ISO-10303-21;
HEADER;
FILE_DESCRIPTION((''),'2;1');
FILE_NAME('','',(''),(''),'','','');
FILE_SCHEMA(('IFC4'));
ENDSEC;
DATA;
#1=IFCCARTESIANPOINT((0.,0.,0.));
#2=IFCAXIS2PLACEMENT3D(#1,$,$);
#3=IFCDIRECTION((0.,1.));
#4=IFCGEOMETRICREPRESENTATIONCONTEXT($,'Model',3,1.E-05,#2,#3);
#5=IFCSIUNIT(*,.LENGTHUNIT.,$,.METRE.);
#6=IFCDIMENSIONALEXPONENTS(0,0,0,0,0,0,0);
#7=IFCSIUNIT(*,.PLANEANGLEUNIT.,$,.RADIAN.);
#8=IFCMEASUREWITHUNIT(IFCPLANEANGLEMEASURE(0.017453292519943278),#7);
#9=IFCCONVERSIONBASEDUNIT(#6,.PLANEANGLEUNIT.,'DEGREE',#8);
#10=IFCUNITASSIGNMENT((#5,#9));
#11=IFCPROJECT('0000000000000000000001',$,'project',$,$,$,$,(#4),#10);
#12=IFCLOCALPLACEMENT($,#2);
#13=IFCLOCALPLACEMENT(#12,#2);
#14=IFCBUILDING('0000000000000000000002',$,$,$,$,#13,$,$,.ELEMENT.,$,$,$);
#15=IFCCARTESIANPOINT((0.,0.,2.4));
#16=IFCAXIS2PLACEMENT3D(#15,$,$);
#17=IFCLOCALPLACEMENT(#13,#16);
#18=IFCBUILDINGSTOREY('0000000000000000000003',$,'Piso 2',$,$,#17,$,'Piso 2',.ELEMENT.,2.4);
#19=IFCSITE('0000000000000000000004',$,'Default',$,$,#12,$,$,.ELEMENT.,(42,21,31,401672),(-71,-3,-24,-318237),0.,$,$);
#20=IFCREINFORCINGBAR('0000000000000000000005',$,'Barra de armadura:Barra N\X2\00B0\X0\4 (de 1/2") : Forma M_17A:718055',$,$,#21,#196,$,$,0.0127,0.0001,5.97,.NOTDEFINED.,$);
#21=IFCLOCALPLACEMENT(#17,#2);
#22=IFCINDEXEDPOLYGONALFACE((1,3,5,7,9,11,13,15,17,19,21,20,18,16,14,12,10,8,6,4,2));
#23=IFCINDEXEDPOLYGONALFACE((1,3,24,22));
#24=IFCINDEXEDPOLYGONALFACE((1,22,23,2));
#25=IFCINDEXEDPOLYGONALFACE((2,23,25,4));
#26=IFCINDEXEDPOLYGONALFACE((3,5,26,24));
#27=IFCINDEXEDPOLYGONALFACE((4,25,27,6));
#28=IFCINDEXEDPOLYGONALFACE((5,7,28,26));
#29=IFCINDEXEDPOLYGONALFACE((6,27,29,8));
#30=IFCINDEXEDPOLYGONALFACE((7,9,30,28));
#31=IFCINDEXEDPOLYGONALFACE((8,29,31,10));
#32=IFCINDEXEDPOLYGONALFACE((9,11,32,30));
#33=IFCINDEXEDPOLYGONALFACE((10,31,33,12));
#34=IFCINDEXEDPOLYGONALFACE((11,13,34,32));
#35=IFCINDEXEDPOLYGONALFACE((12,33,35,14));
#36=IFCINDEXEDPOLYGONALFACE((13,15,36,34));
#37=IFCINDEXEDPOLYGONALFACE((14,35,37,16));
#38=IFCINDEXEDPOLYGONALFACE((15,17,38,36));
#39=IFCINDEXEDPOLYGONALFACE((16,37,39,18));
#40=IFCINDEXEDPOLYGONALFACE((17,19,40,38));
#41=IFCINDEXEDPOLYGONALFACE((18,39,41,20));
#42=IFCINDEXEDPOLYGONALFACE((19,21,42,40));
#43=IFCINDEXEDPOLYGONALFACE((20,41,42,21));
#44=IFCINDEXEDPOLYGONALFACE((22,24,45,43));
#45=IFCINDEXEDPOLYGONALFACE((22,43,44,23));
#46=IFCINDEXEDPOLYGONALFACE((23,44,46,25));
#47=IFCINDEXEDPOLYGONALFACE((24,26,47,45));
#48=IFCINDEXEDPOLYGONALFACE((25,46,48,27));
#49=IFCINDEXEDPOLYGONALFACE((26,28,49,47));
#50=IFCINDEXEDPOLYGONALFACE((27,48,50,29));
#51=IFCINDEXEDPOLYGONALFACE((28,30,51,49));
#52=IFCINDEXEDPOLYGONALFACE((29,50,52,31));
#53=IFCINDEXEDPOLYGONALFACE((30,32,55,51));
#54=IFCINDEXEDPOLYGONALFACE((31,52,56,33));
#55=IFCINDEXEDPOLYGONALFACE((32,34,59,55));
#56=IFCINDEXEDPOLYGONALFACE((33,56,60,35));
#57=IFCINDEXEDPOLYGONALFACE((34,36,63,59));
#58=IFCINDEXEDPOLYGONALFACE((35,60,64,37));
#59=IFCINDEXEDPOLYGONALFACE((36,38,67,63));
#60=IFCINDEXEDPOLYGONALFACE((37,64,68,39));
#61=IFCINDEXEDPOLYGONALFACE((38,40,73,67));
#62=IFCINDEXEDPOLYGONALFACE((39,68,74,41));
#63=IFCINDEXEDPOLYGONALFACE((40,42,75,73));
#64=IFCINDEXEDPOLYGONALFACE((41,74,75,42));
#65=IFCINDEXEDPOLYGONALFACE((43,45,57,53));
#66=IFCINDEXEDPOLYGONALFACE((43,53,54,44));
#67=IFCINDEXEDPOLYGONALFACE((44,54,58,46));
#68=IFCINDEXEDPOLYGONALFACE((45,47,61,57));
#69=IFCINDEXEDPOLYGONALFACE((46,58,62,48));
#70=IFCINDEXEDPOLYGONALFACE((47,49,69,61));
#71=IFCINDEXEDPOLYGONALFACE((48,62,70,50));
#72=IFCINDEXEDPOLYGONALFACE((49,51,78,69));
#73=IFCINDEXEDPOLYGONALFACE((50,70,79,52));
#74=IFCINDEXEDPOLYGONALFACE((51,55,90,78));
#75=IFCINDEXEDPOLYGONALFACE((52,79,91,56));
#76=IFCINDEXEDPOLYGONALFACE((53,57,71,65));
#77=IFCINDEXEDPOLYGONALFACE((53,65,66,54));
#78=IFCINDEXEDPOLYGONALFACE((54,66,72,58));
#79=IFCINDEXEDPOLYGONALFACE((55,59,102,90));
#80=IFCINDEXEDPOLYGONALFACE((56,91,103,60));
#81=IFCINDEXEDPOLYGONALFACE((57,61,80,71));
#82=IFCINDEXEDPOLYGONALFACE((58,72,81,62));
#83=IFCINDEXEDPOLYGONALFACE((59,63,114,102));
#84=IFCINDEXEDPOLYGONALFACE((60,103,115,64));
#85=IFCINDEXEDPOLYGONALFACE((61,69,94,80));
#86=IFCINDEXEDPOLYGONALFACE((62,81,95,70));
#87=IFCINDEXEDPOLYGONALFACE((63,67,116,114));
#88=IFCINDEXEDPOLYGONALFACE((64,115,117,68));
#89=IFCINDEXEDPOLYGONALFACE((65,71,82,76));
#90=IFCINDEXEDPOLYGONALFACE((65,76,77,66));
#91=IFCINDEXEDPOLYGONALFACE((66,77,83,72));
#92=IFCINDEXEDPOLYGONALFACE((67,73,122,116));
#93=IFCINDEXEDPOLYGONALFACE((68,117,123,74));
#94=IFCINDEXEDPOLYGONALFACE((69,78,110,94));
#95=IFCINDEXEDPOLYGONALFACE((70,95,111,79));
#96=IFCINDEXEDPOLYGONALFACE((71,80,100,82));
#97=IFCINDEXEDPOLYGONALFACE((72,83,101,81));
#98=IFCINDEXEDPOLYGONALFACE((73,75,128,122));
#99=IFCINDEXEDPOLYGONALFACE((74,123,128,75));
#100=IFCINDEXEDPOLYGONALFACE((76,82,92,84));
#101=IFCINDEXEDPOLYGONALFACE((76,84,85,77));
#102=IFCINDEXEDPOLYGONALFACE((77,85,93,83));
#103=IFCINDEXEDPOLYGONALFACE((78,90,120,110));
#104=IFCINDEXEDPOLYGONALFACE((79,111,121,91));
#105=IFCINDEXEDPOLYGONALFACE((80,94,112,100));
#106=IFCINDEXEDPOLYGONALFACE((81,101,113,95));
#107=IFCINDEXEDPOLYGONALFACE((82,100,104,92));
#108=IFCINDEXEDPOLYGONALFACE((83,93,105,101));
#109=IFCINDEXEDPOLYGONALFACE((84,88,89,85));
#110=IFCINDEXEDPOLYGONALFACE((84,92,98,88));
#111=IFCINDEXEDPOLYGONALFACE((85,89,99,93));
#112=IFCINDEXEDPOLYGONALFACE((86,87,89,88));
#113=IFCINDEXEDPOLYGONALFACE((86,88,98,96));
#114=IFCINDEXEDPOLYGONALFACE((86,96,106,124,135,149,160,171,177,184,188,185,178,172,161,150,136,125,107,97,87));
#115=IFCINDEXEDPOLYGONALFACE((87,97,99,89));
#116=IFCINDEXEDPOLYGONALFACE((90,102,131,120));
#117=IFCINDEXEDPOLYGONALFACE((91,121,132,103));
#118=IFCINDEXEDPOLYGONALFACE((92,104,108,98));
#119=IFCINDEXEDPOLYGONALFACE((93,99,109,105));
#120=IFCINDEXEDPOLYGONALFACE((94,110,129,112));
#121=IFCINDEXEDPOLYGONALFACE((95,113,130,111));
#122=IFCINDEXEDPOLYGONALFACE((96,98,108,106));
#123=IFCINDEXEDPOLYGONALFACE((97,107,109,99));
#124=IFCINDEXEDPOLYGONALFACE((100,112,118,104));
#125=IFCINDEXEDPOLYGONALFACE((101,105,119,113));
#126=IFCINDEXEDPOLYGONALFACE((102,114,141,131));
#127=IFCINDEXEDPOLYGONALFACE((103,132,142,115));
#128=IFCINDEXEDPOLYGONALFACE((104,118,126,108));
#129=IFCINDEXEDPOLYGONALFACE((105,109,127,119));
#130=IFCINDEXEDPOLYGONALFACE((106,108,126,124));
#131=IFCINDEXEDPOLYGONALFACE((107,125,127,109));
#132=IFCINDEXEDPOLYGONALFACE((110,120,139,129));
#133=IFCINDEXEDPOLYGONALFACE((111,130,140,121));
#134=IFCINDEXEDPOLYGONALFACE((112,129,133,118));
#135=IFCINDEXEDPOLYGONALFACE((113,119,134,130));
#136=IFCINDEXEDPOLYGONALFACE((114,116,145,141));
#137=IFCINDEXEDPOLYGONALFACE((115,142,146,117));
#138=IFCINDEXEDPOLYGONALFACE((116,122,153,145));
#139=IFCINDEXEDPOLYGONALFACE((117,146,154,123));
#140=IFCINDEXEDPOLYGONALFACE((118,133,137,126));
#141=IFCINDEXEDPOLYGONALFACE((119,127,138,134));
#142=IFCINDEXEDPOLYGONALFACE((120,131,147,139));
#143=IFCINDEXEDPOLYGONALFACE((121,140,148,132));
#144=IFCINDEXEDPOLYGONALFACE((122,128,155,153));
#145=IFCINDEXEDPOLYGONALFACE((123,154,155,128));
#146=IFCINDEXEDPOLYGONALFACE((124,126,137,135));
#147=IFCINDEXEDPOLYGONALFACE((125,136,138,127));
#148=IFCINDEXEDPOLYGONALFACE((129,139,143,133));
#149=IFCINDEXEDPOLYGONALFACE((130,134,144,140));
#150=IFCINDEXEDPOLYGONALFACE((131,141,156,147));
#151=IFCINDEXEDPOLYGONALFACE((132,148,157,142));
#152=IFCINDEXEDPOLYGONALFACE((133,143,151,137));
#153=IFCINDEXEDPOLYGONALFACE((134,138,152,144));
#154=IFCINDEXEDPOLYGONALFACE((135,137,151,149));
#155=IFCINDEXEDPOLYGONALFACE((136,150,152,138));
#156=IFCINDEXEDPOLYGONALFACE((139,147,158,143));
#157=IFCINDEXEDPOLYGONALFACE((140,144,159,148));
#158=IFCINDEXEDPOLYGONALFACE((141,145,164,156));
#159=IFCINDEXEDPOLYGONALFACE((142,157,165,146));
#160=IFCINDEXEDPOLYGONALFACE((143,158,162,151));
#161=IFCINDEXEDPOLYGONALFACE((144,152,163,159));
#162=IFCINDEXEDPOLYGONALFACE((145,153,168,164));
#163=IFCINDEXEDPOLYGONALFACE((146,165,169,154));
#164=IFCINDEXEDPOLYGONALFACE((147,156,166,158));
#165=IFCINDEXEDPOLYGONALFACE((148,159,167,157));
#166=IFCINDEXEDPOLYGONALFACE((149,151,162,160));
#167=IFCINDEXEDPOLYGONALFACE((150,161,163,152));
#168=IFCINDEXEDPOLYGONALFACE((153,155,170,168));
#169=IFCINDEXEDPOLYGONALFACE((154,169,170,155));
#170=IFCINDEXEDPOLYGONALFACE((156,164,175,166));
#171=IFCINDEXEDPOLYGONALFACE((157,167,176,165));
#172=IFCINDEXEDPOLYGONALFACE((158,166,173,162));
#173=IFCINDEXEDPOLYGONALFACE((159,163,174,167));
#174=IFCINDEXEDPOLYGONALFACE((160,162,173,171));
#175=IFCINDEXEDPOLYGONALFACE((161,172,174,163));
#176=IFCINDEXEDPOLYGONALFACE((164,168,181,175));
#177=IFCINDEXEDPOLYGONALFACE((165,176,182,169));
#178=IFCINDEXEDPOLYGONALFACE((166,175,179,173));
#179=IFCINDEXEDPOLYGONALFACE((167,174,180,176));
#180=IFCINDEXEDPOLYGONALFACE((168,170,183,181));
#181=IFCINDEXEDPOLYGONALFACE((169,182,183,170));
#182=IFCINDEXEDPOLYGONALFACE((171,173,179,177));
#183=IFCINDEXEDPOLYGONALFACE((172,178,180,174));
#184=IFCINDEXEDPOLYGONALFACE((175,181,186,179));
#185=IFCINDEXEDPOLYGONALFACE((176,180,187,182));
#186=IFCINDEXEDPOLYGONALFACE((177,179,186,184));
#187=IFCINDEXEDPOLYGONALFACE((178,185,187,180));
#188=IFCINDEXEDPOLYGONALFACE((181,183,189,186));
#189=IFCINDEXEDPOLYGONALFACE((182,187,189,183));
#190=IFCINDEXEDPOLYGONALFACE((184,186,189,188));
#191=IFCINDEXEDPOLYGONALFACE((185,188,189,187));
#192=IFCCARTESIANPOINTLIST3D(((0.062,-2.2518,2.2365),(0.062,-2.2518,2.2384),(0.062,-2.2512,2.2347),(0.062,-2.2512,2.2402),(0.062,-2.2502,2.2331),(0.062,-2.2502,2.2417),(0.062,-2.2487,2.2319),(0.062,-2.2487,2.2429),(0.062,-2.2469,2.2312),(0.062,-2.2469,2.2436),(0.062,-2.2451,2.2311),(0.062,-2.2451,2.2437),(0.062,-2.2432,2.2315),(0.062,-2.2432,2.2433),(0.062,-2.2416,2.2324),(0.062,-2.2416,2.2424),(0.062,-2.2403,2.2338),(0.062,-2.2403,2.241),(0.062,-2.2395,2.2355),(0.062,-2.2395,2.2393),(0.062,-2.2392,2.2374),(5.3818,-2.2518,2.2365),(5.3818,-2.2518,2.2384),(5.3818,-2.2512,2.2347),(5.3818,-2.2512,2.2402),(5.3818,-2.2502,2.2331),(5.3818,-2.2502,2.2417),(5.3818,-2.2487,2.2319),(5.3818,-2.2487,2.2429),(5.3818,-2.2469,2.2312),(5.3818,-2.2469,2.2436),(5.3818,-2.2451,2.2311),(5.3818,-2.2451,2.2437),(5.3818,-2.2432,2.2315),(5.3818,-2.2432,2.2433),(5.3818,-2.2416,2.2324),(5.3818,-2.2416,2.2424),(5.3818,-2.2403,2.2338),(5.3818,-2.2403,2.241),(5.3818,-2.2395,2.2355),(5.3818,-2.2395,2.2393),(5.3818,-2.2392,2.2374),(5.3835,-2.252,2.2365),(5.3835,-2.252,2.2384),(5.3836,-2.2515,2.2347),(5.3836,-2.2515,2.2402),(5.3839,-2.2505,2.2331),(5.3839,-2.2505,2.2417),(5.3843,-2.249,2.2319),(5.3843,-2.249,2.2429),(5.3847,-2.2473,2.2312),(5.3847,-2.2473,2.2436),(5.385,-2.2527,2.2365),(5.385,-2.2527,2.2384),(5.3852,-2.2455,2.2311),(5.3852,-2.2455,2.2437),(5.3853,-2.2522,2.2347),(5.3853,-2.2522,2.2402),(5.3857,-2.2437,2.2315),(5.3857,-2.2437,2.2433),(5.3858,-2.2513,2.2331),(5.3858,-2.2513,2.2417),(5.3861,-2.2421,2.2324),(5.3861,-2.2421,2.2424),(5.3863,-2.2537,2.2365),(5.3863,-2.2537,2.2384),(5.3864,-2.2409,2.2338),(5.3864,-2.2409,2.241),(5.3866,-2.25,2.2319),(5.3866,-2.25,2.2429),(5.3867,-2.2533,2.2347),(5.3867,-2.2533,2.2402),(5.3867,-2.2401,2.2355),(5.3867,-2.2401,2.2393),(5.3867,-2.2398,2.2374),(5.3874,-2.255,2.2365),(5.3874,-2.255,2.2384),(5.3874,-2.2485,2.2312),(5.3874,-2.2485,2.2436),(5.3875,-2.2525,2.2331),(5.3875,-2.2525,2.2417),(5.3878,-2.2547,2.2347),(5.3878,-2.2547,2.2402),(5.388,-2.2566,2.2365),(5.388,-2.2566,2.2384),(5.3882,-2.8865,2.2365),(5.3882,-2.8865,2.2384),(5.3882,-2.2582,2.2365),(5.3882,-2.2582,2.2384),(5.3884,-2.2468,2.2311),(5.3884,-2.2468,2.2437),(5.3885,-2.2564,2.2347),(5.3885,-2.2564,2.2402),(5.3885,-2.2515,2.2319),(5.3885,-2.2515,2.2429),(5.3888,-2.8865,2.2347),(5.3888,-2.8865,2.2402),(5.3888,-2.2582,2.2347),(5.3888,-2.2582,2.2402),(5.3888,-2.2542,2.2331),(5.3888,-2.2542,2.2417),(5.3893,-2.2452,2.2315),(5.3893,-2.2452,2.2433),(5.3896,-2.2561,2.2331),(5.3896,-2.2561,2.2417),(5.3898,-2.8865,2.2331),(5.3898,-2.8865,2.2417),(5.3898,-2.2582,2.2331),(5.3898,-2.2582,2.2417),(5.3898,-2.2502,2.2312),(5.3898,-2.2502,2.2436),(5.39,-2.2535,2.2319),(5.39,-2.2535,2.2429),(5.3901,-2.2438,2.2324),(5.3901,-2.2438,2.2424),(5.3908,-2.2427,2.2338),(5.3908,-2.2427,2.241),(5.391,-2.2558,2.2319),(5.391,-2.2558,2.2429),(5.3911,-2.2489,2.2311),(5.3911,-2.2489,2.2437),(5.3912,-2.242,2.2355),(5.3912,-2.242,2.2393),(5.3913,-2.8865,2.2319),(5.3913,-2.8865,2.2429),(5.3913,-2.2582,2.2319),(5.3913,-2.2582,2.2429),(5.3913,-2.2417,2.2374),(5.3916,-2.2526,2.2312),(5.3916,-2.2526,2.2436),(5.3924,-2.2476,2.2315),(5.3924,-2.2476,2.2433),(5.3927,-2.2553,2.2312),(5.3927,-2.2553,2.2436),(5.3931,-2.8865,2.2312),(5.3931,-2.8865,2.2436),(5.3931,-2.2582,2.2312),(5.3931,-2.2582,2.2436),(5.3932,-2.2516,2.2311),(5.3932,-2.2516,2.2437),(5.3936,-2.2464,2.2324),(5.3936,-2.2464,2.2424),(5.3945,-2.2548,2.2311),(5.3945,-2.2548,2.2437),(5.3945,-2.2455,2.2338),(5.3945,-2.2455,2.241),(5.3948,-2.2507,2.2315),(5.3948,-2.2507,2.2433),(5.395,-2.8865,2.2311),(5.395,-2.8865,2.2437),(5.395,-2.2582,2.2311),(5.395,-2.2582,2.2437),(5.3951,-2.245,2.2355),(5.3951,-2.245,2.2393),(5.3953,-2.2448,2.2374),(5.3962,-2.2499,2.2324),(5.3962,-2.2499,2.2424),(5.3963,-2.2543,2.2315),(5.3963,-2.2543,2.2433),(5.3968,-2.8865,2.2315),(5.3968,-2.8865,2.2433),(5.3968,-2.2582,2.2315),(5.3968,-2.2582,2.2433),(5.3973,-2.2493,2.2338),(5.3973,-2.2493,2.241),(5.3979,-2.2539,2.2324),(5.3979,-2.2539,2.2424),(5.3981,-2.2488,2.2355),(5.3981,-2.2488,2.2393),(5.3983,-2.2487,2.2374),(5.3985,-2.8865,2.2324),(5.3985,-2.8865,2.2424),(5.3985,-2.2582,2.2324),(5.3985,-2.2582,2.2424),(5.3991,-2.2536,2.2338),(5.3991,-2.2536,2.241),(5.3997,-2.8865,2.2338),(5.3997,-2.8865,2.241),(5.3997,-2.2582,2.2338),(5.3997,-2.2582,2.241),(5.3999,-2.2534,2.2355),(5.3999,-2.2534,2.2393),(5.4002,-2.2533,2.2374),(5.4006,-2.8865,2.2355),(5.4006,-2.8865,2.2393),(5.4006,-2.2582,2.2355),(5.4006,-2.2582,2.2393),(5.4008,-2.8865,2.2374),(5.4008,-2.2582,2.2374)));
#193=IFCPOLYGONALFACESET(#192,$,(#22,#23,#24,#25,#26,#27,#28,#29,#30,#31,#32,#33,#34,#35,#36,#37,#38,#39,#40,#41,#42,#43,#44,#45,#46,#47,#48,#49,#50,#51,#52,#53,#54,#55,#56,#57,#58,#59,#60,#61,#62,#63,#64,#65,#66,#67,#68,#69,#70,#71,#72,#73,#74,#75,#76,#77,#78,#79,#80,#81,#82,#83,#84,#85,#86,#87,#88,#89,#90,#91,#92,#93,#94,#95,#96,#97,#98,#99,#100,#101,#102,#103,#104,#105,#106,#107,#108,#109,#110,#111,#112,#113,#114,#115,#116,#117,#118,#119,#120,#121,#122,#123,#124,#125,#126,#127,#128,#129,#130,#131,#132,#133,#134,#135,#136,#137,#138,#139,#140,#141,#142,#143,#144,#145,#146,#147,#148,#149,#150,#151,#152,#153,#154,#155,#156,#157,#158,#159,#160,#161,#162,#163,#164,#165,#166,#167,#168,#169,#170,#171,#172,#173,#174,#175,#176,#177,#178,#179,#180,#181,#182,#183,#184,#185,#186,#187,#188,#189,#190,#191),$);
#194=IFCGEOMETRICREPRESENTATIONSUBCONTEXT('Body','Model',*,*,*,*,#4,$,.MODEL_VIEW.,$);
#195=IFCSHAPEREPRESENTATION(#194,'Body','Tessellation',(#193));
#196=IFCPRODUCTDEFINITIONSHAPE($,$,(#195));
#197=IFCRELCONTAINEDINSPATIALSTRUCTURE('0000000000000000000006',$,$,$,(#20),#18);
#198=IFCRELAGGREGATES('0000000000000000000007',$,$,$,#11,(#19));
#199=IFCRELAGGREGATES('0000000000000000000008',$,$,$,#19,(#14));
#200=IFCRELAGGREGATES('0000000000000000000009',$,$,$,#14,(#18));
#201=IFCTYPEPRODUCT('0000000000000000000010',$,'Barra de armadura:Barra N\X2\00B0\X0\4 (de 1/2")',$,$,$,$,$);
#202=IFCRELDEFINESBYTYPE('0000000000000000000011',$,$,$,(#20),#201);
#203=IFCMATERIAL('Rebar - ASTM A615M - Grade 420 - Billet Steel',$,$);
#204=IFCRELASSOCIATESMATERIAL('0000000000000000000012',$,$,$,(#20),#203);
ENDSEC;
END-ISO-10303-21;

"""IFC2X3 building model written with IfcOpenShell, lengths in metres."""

from ifc_helpers import new_model, entity, si_unit, converted_unit, direction, frame, origin, place, context, subcontext, project, spatial, material, type_object, element, save


model = new_model("IFC2X3")

# Units and contexts
model_context = context("Model", 3, precision=1e-05, world=origin(), true_north=direction((0.0, 1.0)))
body_context = subcontext(model_context, "Body", "Model", "MODEL_VIEW")
ifc_project = project(units=[si_unit("LENGTHUNIT", "METRE"), converted_unit("PLANEANGLEUNIT", "DEGREE", entity("IfcPlaneAngleMeasure", 0.017453292519943278), si_unit("PLANEANGLEUNIT", "RADIAN"), dimensions=[0, 0, 0, 0, 0, 0, 0])], contexts=[model_context])

# Site, building, storey
site_placement = place(None, origin())
site = spatial("IfcSite", under=ifc_project, at=site_placement, Name="Default", CompositionType="ELEMENT", RefLatitude=(42, 21, 31, 401672), RefLongitude=(-71, -3, -24, -318237), RefElevation=0.0)
building_placement = place(site_placement, origin())
building = spatial("IfcBuilding", under=site, at=building_placement, CompositionType="ELEMENT")
storey_placement = place(building_placement, frame((0.0, 0.0, 2.4)))
storey = spatial("IfcBuildingStorey", under=building, at=storey_placement, Name="Piso 2", LongName="Piso 2", CompositionType="ELEMENT", Elevation=2.4)

# Reinforcing bar
ifc_material_1 = material(Name="Rebar - ASTM A615M - Grade 420 - Billet Steel")
type_product_1 = type_object("IfcTypeProduct", Name="Barra de armadura:Barra N°4 (de 1/2\")")
reinforcing_bar_1_placement = place(storey_placement, origin())
element("IfcReinforcingBar", 1, at=reinforcing_bar_1_placement, inside=storey, type_object=type_product_1, material=ifc_material_1, Name="Barra de armadura:Barra N°4 (de 1/2\") : Forma M_17A:718055", BarLength=5.97, BarRole="NOTDEFINED", CrossSectionArea=0.0001, NominalDiameter=0.0127, context=body_context, shape_type="AdvancedSweptSolid", body=[
    entity("IfcSweptDiskSolid", entity("IfcCompositeCurve", [entity("IfcCompositeCurveSegment", "CONTINUOUS", True, entity("IfcPolyline", [entity("IfcCartesianPoint", [0.062, -2.2455, 2.2374]), entity("IfcCartesianPoint", [5.3818, -2.2455, 2.2374])])), entity("IfcCompositeCurveSegment", "CONTINUOUS", True, entity("IfcTrimmedCurve", entity("IfcCircle", entity("IfcAxis2Placement3D", entity("IfcCartesianPoint", [5.3818, -2.2582, 2.2374]), entity("IfcDirection", [0.0, 0.0, -1.0]), entity("IfcDirection", [1.0, 0.0, 0.0])), 0.0127), [entity("IfcParameterValue", 270.0)], [entity("IfcParameterValue", 360.0)], True, "PARAMETER")), entity("IfcCompositeCurveSegment", "CONTINUOUS", True, entity("IfcPolyline", [entity("IfcCartesianPoint", [5.3945, -2.2582, 2.2374]), entity("IfcCartesianPoint", [5.3945, -2.8865, 2.2374])]))], False), 0.0063, None, 0.0, 92.0),
])

save(model, "model.ifc")
